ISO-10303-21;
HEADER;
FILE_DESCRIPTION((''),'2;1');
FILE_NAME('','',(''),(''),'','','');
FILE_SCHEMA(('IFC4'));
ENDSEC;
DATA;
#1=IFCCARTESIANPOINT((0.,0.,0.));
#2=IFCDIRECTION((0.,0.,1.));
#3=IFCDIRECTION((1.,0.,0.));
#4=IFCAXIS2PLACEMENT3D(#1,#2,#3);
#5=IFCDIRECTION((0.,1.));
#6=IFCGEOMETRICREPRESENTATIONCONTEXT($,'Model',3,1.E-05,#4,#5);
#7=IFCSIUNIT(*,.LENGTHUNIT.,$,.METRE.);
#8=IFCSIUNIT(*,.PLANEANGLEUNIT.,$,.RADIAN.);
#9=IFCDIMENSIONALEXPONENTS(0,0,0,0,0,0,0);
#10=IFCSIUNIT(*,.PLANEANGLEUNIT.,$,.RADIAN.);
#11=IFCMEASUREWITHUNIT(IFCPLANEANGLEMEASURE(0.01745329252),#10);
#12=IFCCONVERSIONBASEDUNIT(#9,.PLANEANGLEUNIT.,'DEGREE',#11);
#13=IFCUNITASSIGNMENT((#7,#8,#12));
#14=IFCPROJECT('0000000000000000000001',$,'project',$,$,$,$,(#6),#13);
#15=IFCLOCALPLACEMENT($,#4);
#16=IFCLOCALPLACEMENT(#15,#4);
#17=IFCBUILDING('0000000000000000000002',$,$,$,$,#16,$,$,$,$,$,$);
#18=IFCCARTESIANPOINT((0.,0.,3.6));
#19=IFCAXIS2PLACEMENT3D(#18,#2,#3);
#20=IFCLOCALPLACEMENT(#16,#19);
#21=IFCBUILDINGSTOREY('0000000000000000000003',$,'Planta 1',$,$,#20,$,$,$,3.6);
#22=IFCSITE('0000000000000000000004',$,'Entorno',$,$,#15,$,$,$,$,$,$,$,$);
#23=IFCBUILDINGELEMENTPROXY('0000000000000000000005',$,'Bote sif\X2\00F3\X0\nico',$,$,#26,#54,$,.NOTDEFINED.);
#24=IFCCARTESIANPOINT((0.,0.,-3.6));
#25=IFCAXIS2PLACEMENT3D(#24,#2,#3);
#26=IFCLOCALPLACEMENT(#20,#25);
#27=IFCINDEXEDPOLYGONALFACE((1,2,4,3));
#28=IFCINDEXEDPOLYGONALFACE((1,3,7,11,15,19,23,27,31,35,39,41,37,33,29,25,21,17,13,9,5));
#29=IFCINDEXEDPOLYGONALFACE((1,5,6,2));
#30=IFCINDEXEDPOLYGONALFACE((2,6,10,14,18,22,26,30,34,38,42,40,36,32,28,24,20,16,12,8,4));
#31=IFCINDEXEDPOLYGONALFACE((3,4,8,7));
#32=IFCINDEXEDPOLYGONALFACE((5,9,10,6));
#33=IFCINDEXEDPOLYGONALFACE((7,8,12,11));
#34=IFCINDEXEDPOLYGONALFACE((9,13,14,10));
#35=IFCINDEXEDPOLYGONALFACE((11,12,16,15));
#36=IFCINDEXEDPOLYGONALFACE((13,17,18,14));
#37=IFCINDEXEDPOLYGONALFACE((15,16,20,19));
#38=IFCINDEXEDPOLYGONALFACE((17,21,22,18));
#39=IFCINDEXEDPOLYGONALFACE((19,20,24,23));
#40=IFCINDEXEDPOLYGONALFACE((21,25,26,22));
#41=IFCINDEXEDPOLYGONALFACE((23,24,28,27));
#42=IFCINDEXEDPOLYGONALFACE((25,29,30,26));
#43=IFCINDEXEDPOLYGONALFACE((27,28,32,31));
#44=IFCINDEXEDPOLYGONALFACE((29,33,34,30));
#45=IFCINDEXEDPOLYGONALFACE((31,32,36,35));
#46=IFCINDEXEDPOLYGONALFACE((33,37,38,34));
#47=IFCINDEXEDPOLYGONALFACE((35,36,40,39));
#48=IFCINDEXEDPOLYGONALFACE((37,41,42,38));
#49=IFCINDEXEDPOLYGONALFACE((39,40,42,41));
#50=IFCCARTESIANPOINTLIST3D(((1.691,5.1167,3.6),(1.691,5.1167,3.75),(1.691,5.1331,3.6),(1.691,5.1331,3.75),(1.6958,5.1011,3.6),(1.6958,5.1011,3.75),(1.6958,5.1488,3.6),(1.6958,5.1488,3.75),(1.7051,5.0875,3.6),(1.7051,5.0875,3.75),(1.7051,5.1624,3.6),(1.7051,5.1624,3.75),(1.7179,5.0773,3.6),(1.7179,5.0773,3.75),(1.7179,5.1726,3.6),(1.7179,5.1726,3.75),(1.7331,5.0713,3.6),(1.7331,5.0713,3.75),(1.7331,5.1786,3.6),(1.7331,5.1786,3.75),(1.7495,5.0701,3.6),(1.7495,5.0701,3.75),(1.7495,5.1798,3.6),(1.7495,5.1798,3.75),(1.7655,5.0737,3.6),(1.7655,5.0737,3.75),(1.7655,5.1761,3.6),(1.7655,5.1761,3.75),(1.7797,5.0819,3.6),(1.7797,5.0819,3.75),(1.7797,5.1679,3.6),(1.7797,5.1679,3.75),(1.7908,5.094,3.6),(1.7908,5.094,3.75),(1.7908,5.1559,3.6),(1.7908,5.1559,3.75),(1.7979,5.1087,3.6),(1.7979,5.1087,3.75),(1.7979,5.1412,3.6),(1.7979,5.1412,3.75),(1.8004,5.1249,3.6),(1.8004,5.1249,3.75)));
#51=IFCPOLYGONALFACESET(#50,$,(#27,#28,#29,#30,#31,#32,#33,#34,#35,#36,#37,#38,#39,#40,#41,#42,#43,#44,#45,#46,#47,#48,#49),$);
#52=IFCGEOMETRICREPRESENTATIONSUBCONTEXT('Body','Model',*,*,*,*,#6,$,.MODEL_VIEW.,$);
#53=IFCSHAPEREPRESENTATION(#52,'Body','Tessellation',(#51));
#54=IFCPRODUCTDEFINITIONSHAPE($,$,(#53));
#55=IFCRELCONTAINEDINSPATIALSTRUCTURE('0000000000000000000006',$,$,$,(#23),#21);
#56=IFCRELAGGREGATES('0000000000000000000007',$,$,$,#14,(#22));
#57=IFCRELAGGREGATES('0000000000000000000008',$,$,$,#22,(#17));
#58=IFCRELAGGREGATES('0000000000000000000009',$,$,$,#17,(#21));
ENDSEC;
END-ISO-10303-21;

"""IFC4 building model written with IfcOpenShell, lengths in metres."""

from ifc_helpers import new_model, entity, si_unit, converted_unit, direction, frame, origin_with_axes, place, context, subcontext, project, spatial, element, save


model = new_model("IFC4")

# Units and contexts
model_context = context("Model", 3, precision=1e-05, world=origin_with_axes(), true_north=direction((0.0, 1.0)))
body_context = subcontext(model_context, "Body", "Model", "MODEL_VIEW")
ifc_project = project(units=[si_unit("LENGTHUNIT", "METRE"), si_unit("PLANEANGLEUNIT", "RADIAN"), converted_unit("PLANEANGLEUNIT", "DEGREE", entity("IfcPlaneAngleMeasure", 0.01745329252), si_unit("PLANEANGLEUNIT", "RADIAN"), dimensions=[0, 0, 0, 0, 0, 0, 0])], contexts=[model_context])

# Site, building, storey
site_placement = place(None, origin_with_axes())
site = spatial("IfcSite", under=ifc_project, at=site_placement, Name="Entorno")
building_placement = place(site_placement, origin_with_axes())
building = spatial("IfcBuilding", under=site, at=building_placement)
storey_placement = place(building_placement, frame((0.0, 0.0, 3.6), z_axis=(0.0, 0.0, 1.0), x_axis=(1.0, 0.0, 0.0)))
storey = spatial("IfcBuildingStorey", under=building, at=storey_placement, Name="Planta 1", Elevation=3.6)

# Building element proxy
proxy_1_placement = place(storey_placement, frame((0.0, 0.0, -3.6), z_axis=(0.0, 0.0, 1.0), x_axis=(1.0, 0.0, 0.0)))
ifc_direction_1 = entity("IfcDirection", [0.0, 0.0, 1.0])
element("IfcBuildingElementProxy", 1, at=proxy_1_placement, inside=storey, Name="Bote sifónico", PredefinedType="NOTDEFINED", context=body_context, shape_type="Brep", body=[
    entity("IfcExtrudedAreaSolidTapered", entity("IfcCircleProfileDef", "AREA", None, entity("IfcAxis2Placement2D", entity("IfcCartesianPoint", [0.0, 0.0]), entity("IfcDirection", [1.0, 0.0])), 0.055), entity("IfcAxis2Placement3D", entity("IfcCartesianPoint", [1.7454, 5.1249, 3.6]), ifc_direction_1, entity("IfcDirection", [1.0, 0.0, 0.0])), ifc_direction_1, 0.15, entity("IfcCircleProfileDef", "AREA", None, entity("IfcAxis2Placement2D", entity("IfcCartesianPoint", [0.0, 0.0]), entity("IfcDirection", [1.0, 0.0])), 0.055)),
])

save(model, "model.ifc")
